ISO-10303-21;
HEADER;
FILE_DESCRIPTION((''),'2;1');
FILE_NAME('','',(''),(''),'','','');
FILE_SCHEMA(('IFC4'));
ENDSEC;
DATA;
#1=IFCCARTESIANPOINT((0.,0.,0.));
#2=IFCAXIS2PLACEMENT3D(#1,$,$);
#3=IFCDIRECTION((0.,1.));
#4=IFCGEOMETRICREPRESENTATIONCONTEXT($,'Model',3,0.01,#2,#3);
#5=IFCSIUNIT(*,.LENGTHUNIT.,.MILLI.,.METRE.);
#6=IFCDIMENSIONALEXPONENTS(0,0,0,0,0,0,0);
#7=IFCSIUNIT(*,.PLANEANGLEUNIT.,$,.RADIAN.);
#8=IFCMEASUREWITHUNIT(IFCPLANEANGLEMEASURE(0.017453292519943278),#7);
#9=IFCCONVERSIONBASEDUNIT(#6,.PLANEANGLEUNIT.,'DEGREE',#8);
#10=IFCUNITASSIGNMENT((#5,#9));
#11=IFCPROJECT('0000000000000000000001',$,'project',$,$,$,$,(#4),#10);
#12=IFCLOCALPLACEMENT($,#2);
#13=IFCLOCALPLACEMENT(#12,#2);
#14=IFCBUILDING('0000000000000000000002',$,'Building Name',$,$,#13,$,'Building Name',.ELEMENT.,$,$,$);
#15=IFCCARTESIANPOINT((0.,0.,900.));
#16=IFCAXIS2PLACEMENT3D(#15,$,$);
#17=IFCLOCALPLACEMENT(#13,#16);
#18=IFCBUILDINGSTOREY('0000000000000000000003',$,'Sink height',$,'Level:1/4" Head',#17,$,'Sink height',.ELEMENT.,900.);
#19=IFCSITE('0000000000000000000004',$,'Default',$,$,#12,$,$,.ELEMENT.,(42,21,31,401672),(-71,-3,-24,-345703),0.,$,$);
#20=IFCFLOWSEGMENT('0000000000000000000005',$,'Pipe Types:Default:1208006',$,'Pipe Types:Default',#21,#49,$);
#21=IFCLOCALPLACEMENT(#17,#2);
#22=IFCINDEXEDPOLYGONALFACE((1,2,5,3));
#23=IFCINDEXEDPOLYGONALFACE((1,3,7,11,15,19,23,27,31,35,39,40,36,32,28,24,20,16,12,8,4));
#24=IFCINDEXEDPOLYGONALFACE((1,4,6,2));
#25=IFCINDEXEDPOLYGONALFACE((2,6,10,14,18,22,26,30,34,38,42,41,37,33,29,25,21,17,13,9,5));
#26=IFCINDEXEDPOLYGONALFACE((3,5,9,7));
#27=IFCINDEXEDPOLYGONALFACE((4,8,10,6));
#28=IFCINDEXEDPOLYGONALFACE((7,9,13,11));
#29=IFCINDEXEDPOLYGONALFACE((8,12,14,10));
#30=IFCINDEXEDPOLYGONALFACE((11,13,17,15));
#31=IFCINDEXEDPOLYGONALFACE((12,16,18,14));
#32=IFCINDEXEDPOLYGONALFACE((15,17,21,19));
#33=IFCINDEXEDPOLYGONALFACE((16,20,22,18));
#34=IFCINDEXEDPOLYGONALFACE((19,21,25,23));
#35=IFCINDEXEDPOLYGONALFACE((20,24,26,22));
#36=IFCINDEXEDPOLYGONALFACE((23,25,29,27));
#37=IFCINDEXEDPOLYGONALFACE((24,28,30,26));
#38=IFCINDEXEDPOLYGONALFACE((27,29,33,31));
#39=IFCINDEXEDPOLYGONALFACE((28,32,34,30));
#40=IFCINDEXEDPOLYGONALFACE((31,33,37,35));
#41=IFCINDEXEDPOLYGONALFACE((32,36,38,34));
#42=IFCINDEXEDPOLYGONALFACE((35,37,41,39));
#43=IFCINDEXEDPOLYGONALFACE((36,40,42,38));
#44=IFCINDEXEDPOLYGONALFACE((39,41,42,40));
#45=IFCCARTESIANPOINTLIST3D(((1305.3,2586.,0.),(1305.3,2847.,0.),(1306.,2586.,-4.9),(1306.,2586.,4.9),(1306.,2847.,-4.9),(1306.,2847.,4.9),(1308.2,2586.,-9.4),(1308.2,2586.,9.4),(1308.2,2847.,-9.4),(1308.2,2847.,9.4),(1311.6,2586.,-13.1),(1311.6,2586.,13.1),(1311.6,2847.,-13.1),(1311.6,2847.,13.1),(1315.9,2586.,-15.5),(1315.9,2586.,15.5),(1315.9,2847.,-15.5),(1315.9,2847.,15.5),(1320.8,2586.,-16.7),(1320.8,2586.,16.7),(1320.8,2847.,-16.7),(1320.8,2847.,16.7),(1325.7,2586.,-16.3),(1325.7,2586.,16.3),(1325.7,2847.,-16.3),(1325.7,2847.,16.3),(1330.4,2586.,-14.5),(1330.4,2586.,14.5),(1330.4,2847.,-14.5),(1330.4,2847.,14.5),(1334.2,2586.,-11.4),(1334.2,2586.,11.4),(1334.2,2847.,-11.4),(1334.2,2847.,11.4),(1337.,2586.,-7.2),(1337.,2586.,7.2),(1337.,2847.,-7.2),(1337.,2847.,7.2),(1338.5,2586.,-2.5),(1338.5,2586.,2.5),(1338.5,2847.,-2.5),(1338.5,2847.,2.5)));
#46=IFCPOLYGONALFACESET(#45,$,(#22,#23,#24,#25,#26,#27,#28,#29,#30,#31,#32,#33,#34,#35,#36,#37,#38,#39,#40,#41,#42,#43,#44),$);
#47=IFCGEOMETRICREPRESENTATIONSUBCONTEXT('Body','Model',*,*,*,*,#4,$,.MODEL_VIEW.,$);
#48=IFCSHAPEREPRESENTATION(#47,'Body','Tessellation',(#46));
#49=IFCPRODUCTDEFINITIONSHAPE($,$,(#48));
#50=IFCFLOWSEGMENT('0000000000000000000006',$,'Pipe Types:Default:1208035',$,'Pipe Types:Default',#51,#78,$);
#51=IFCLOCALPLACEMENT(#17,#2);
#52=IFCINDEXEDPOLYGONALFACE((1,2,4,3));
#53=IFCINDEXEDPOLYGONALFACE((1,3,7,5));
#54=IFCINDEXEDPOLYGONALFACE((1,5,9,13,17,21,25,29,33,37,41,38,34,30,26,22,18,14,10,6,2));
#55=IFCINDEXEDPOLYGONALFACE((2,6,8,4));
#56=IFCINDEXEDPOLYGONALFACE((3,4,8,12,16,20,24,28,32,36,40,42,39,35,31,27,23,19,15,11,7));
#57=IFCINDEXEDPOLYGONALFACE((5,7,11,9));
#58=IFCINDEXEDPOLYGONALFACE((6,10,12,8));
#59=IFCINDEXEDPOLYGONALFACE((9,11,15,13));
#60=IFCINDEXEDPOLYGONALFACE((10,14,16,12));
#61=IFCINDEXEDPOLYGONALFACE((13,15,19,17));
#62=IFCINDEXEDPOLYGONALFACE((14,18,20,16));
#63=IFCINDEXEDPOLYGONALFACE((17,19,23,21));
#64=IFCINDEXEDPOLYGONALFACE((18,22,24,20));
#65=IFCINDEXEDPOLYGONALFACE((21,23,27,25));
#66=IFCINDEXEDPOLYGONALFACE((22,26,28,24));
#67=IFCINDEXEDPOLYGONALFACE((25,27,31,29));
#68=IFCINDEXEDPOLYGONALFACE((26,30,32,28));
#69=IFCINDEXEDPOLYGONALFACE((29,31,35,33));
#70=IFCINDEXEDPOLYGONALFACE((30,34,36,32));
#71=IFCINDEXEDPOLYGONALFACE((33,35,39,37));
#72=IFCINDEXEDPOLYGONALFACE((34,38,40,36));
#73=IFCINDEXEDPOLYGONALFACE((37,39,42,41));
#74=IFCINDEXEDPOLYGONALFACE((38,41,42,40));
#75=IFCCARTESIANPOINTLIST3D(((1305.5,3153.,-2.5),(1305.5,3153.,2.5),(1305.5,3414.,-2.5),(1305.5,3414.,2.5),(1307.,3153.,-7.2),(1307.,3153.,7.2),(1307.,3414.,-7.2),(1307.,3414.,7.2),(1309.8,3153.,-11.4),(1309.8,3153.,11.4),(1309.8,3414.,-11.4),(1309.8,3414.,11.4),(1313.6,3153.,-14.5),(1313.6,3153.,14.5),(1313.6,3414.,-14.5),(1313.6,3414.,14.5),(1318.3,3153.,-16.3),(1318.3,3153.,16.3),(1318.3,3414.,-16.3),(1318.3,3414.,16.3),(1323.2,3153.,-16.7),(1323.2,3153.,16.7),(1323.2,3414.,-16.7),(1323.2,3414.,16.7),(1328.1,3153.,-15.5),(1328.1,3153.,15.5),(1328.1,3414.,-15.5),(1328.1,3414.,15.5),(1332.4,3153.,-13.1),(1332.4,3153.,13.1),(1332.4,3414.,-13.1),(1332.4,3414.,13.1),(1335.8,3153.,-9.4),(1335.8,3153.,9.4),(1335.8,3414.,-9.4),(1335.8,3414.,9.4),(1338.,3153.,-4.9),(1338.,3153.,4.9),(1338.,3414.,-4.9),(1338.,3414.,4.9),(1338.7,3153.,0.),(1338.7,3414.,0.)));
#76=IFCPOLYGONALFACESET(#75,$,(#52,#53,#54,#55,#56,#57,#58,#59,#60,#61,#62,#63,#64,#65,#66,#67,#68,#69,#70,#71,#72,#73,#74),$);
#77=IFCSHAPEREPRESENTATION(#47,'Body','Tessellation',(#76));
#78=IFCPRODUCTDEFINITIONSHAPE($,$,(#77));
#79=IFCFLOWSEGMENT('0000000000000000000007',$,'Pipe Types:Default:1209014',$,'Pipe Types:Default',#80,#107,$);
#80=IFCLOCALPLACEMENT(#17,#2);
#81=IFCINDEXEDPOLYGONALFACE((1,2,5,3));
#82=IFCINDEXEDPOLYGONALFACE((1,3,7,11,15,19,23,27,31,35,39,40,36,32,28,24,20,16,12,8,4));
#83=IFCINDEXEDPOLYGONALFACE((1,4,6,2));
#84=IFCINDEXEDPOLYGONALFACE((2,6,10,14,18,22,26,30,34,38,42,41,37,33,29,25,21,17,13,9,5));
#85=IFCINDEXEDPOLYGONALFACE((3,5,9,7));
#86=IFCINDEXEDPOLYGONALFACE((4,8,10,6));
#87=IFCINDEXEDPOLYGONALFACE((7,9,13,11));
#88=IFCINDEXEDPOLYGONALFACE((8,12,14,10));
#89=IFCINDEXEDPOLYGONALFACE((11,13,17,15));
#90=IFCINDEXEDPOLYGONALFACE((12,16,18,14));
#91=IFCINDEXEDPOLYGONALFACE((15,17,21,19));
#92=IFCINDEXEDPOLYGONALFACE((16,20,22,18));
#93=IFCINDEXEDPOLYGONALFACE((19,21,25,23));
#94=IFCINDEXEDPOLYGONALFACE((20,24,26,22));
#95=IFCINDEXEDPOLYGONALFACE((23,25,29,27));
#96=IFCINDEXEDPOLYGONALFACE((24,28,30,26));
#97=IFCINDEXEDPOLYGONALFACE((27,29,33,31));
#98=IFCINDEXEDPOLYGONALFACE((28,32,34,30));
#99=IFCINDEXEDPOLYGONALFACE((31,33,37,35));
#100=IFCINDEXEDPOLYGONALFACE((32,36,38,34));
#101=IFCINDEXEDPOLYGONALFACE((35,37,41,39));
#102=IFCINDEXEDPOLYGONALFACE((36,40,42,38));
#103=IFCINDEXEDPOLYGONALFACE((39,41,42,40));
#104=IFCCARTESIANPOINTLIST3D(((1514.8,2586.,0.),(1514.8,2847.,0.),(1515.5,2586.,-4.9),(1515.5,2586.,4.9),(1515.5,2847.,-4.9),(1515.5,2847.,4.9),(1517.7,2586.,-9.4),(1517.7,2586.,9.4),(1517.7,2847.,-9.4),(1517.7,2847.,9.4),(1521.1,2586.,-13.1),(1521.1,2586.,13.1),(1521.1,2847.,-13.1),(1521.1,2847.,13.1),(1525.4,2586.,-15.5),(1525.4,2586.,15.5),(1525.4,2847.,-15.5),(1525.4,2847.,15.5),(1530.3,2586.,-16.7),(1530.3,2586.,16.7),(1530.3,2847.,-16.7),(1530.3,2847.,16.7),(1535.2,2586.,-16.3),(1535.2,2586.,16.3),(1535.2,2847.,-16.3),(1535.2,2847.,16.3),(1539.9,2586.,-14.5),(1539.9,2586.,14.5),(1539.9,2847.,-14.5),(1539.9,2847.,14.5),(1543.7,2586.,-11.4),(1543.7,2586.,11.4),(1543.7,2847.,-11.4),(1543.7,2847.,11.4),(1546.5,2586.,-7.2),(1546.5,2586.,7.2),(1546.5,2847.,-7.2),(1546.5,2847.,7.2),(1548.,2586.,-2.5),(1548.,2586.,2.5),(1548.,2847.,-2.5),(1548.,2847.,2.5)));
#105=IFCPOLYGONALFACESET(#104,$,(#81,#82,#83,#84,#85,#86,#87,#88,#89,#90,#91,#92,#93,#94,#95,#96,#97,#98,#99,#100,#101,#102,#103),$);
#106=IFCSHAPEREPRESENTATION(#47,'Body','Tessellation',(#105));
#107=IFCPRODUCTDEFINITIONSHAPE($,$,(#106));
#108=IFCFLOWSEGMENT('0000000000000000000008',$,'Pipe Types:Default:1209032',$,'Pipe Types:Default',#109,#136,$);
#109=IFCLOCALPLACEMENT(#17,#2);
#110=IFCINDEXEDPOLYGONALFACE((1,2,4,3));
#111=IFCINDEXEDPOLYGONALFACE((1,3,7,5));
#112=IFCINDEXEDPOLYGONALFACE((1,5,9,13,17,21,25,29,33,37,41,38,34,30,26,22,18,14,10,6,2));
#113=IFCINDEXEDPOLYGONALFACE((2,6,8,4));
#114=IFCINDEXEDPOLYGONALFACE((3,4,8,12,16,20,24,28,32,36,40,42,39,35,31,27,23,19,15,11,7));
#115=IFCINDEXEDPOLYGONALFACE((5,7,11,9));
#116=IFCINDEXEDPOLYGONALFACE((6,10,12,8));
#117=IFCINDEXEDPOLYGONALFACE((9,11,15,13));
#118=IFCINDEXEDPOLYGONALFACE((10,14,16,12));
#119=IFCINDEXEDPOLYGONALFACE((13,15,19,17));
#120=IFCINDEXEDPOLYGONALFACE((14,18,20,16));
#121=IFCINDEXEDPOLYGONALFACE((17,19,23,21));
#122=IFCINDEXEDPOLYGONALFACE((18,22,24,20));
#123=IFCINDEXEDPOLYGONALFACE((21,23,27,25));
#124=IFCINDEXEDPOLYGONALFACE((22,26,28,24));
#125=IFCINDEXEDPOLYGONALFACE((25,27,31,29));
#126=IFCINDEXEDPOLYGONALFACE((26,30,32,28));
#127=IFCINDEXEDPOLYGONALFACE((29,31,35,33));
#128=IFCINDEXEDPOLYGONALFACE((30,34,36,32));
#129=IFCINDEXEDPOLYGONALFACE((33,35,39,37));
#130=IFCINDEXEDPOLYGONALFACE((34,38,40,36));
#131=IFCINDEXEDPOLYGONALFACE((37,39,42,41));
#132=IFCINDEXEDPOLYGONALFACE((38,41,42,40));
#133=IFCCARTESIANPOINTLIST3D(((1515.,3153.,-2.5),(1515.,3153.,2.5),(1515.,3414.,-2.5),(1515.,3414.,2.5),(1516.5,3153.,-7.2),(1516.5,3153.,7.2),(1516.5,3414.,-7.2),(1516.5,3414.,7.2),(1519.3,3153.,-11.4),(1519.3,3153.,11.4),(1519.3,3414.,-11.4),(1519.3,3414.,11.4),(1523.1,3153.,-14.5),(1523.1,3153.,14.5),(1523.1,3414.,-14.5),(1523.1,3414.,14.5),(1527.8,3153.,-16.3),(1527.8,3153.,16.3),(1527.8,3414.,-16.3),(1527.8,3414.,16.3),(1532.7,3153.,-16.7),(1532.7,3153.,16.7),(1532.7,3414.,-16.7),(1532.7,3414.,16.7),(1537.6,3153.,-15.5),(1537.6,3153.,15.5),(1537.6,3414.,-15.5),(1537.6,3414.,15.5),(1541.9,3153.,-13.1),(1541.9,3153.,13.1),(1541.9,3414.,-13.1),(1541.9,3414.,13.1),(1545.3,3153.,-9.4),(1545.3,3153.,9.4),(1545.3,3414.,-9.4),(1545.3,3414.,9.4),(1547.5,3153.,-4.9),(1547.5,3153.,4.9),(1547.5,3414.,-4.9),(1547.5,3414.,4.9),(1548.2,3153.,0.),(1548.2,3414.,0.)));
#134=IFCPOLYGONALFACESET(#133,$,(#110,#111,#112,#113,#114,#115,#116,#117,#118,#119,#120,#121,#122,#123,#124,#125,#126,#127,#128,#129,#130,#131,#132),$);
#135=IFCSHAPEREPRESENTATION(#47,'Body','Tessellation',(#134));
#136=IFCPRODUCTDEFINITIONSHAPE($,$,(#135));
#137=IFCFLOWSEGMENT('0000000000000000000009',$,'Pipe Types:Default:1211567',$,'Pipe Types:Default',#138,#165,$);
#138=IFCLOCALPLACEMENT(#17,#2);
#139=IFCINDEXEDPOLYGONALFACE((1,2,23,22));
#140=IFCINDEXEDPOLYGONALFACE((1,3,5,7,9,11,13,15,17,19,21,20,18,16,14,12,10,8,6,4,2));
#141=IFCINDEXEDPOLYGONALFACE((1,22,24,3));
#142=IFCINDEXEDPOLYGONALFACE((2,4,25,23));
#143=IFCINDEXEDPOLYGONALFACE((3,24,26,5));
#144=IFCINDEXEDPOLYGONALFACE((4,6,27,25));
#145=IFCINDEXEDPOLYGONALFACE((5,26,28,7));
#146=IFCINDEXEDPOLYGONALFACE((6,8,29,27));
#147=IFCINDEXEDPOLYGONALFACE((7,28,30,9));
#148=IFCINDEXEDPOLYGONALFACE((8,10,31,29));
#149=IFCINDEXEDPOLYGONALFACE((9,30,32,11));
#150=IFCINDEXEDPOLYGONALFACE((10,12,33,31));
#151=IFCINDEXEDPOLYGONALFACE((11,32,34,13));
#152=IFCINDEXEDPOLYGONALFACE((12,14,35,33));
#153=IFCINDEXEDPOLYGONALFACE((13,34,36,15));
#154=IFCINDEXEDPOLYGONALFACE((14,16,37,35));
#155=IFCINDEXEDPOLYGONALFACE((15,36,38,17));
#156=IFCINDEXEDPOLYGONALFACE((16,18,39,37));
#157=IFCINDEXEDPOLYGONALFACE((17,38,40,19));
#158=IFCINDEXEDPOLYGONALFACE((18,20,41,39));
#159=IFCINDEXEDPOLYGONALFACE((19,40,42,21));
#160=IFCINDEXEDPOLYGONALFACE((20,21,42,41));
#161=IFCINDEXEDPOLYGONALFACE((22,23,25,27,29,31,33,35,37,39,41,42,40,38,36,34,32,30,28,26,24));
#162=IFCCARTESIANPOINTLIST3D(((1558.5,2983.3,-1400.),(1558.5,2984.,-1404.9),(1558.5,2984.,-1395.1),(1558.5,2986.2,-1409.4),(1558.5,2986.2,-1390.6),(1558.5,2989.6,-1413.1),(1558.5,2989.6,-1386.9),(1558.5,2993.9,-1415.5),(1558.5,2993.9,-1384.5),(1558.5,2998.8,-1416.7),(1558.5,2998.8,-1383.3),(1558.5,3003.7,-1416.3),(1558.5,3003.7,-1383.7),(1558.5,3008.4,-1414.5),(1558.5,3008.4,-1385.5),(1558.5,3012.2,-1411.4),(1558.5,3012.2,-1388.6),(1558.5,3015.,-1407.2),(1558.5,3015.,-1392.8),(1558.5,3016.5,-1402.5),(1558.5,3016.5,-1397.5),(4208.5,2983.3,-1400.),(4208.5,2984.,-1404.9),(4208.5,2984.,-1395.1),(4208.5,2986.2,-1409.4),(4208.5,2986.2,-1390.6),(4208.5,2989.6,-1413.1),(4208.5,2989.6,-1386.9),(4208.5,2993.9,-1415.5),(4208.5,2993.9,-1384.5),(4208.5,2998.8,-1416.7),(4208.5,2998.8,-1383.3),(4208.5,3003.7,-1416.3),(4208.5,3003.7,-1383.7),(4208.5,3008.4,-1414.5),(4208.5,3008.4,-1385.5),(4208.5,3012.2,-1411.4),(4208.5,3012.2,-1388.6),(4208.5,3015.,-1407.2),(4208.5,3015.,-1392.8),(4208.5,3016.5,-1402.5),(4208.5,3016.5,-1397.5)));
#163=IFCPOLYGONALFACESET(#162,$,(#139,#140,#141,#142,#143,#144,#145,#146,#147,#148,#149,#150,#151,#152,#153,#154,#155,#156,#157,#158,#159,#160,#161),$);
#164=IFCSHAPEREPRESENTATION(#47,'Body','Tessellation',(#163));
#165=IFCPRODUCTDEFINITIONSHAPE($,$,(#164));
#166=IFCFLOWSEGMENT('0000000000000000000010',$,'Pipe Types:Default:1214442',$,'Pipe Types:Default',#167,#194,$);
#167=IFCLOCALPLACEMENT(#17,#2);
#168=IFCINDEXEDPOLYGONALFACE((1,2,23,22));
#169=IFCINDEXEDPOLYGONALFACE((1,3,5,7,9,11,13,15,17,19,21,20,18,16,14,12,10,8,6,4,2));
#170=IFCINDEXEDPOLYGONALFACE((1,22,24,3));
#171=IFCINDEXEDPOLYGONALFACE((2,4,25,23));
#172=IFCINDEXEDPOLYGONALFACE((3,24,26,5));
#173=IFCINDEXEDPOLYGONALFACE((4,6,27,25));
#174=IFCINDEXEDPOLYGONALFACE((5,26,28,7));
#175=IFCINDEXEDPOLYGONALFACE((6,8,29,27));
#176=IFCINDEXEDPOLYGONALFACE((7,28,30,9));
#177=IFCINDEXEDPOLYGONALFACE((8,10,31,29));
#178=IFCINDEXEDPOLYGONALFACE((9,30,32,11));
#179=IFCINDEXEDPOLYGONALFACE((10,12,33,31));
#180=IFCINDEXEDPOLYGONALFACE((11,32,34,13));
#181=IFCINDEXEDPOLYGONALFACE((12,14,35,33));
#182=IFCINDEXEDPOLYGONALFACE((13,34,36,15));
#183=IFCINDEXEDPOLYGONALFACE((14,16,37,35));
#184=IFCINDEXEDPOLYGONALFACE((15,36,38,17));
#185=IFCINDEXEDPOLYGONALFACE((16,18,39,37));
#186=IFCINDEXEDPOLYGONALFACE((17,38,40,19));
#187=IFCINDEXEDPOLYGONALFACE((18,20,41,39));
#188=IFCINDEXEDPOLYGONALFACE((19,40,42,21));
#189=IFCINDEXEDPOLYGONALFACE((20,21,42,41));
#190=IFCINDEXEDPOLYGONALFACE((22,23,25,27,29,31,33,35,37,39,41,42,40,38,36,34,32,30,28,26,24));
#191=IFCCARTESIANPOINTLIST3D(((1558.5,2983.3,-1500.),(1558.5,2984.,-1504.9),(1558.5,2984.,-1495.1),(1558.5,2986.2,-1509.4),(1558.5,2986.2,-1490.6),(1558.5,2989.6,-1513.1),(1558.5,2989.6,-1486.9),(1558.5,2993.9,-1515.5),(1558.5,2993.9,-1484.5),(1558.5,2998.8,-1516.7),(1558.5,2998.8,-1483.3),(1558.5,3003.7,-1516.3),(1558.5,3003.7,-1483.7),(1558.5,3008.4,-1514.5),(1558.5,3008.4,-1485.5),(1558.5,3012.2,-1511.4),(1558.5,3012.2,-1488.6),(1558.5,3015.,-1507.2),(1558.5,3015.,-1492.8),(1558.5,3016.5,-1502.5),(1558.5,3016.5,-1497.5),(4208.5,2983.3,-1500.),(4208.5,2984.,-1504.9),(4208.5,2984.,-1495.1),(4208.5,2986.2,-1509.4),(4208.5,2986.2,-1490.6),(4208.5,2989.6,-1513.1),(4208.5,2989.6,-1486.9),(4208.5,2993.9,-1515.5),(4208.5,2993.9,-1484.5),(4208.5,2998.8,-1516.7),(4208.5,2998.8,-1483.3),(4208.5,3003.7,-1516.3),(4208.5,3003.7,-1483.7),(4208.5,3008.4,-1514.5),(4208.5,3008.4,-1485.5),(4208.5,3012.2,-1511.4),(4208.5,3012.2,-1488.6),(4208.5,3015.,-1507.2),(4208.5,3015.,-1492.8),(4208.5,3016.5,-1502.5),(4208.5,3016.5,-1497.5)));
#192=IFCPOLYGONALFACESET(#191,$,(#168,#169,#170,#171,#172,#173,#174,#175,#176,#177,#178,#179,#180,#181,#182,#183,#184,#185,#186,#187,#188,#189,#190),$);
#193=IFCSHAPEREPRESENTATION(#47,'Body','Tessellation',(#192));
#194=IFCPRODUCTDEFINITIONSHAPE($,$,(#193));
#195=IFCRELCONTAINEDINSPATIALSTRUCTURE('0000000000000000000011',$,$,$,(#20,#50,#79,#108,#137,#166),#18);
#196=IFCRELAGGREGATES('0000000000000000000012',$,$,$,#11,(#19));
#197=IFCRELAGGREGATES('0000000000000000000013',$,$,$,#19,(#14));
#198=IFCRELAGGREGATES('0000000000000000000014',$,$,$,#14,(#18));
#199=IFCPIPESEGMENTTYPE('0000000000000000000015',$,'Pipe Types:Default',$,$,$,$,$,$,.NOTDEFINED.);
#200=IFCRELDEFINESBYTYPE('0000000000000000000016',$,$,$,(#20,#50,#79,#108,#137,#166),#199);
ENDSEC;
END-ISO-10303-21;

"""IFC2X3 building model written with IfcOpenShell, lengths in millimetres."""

from ifc_helpers import new_model, entity, si_unit, converted_unit, direction, frame, frame_2d, origin, origin_2d_with_axis, place, context, subcontext, project, spatial, circle, extrude, type_object, element, save


model = new_model("IFC2X3")

# Units and contexts
model_context = context("Model", 3, precision=0.01, world=origin(), true_north=direction((0.0, 1.0)))
body_context = subcontext(model_context, "Body", "Model", "MODEL_VIEW")
ifc_project = project(units=[si_unit("LENGTHUNIT", "METRE", prefix="MILLI"), converted_unit("PLANEANGLEUNIT", "DEGREE", entity("IfcPlaneAngleMeasure", 0.017453292519943278), si_unit("PLANEANGLEUNIT", "RADIAN"), dimensions=[0, 0, 0, 0, 0, 0, 0])], contexts=[model_context])

# Site, building, storey
site_placement = place(None, origin())
site = spatial("IfcSite", under=ifc_project, at=site_placement, Name="Default", CompositionType="ELEMENT", RefLatitude=(42, 21, 31, 401672), RefLongitude=(-71, -3, -24, -345703), RefElevation=0.0)
building_placement = place(site_placement, origin())
building = spatial("IfcBuilding", under=site, at=building_placement, Name="Building Name", LongName="Building Name", CompositionType="ELEMENT")
storey_placement = place(building_placement, frame((0.0, 0.0, 900.0)))
storey = spatial("IfcBuildingStorey", under=building, at=storey_placement, Name="Sink height", ObjectType="Level:1/4\" Head", LongName="Sink height", CompositionType="ELEMENT", Elevation=900.0)

# Flow segments
pipe_segment_type = type_object("IfcPipeSegmentType", Name="Pipe Types:Default", PredefinedType="NOTDEFINED")
flow_segment_1_placement = place(storey_placement, origin())
element("IfcFlowSegment", 1, at=flow_segment_1_placement, inside=storey, type_object=pipe_segment_type, Name="Pipe Types:Default:1208006", ObjectType="Pipe Types:Default", context=body_context, shape_type="SweptSolid", body=[
    extrude(circle(Radius=16.7, at=frame_2d((0.0, 0.0), x_axis=(1.0, 0.0))), frame((1322.0, 2586.0, 0.0), z_axis=(0.0, 1.0, 0.0), x_axis=(-1.0, 0.0, 0.0)), (0.0, 0.0, 1.0), 261.0),
])
flow_segment_2_placement = place(storey_placement, origin())
element("IfcFlowSegment", 2, at=flow_segment_2_placement, inside=storey, type_object=pipe_segment_type, Name="Pipe Types:Default:1208035", ObjectType="Pipe Types:Default", context=body_context, shape_type="SweptSolid", body=[
    extrude(circle(Radius=16.7, at=origin_2d_with_axis()), frame((1322.0, 3153.0, 0.0), z_axis=(0.0, 1.0, 0.0), x_axis=(1.0, 0.0, 0.0)), (0.0, 0.0, 1.0), 261.0),
])
flow_segment_3_placement = place(storey_placement, origin())
element("IfcFlowSegment", 3, at=flow_segment_3_placement, inside=storey, type_object=pipe_segment_type, Name="Pipe Types:Default:1209014", ObjectType="Pipe Types:Default", context=body_context, shape_type="SweptSolid", body=[
    extrude(circle(Radius=16.7, at=frame_2d((0.0, 0.0), x_axis=(1.0, 0.0))), frame((1531.5, 2586.0, 0.0), z_axis=(0.0, 1.0, 0.0), x_axis=(-1.0, 0.0, 0.0)), (0.0, 0.0, 1.0), 261.0),
])
flow_segment_4_placement = place(storey_placement, origin())
element("IfcFlowSegment", 4, at=flow_segment_4_placement, inside=storey, type_object=pipe_segment_type, Name="Pipe Types:Default:1209032", ObjectType="Pipe Types:Default", context=body_context, shape_type="SweptSolid", body=[
    extrude(circle(Radius=16.7, at=origin_2d_with_axis()), frame((1531.5, 3153.0, 0.0), z_axis=(0.0, 1.0, 0.0), x_axis=(1.0, 0.0, 0.0)), (0.0, 0.0, 1.0), 261.0),
])
flow_segment_5_placement = place(storey_placement, origin())
element("IfcFlowSegment", 5, at=flow_segment_5_placement, inside=storey, type_object=pipe_segment_type, Name="Pipe Types:Default:1211567", ObjectType="Pipe Types:Default", context=body_context, shape_type="SweptSolid", body=[
    extrude(circle(Radius=16.7, at=origin_2d_with_axis()), frame((1558.5, 3000.0, -1400.0), z_axis=(1.0, 0.0, 0.0), x_axis=(0.0, -1.0, 0.0)), (0.0, 0.0, 1.0), 2650.0),
])
flow_segment_6_placement = place(storey_placement, origin())
element("IfcFlowSegment", 6, at=flow_segment_6_placement, inside=storey, type_object=pipe_segment_type, Name="Pipe Types:Default:1214442", ObjectType="Pipe Types:Default", context=body_context, shape_type="SweptSolid", body=[
    extrude(circle(Radius=16.7, at=origin_2d_with_axis()), frame((1558.5, 3000.0, -1500.0), z_axis=(1.0, 0.0, 0.0), x_axis=(0.0, -1.0, 0.0)), (0.0, 0.0, 1.0), 2650.0),
])

save(model, "model.ifc")
